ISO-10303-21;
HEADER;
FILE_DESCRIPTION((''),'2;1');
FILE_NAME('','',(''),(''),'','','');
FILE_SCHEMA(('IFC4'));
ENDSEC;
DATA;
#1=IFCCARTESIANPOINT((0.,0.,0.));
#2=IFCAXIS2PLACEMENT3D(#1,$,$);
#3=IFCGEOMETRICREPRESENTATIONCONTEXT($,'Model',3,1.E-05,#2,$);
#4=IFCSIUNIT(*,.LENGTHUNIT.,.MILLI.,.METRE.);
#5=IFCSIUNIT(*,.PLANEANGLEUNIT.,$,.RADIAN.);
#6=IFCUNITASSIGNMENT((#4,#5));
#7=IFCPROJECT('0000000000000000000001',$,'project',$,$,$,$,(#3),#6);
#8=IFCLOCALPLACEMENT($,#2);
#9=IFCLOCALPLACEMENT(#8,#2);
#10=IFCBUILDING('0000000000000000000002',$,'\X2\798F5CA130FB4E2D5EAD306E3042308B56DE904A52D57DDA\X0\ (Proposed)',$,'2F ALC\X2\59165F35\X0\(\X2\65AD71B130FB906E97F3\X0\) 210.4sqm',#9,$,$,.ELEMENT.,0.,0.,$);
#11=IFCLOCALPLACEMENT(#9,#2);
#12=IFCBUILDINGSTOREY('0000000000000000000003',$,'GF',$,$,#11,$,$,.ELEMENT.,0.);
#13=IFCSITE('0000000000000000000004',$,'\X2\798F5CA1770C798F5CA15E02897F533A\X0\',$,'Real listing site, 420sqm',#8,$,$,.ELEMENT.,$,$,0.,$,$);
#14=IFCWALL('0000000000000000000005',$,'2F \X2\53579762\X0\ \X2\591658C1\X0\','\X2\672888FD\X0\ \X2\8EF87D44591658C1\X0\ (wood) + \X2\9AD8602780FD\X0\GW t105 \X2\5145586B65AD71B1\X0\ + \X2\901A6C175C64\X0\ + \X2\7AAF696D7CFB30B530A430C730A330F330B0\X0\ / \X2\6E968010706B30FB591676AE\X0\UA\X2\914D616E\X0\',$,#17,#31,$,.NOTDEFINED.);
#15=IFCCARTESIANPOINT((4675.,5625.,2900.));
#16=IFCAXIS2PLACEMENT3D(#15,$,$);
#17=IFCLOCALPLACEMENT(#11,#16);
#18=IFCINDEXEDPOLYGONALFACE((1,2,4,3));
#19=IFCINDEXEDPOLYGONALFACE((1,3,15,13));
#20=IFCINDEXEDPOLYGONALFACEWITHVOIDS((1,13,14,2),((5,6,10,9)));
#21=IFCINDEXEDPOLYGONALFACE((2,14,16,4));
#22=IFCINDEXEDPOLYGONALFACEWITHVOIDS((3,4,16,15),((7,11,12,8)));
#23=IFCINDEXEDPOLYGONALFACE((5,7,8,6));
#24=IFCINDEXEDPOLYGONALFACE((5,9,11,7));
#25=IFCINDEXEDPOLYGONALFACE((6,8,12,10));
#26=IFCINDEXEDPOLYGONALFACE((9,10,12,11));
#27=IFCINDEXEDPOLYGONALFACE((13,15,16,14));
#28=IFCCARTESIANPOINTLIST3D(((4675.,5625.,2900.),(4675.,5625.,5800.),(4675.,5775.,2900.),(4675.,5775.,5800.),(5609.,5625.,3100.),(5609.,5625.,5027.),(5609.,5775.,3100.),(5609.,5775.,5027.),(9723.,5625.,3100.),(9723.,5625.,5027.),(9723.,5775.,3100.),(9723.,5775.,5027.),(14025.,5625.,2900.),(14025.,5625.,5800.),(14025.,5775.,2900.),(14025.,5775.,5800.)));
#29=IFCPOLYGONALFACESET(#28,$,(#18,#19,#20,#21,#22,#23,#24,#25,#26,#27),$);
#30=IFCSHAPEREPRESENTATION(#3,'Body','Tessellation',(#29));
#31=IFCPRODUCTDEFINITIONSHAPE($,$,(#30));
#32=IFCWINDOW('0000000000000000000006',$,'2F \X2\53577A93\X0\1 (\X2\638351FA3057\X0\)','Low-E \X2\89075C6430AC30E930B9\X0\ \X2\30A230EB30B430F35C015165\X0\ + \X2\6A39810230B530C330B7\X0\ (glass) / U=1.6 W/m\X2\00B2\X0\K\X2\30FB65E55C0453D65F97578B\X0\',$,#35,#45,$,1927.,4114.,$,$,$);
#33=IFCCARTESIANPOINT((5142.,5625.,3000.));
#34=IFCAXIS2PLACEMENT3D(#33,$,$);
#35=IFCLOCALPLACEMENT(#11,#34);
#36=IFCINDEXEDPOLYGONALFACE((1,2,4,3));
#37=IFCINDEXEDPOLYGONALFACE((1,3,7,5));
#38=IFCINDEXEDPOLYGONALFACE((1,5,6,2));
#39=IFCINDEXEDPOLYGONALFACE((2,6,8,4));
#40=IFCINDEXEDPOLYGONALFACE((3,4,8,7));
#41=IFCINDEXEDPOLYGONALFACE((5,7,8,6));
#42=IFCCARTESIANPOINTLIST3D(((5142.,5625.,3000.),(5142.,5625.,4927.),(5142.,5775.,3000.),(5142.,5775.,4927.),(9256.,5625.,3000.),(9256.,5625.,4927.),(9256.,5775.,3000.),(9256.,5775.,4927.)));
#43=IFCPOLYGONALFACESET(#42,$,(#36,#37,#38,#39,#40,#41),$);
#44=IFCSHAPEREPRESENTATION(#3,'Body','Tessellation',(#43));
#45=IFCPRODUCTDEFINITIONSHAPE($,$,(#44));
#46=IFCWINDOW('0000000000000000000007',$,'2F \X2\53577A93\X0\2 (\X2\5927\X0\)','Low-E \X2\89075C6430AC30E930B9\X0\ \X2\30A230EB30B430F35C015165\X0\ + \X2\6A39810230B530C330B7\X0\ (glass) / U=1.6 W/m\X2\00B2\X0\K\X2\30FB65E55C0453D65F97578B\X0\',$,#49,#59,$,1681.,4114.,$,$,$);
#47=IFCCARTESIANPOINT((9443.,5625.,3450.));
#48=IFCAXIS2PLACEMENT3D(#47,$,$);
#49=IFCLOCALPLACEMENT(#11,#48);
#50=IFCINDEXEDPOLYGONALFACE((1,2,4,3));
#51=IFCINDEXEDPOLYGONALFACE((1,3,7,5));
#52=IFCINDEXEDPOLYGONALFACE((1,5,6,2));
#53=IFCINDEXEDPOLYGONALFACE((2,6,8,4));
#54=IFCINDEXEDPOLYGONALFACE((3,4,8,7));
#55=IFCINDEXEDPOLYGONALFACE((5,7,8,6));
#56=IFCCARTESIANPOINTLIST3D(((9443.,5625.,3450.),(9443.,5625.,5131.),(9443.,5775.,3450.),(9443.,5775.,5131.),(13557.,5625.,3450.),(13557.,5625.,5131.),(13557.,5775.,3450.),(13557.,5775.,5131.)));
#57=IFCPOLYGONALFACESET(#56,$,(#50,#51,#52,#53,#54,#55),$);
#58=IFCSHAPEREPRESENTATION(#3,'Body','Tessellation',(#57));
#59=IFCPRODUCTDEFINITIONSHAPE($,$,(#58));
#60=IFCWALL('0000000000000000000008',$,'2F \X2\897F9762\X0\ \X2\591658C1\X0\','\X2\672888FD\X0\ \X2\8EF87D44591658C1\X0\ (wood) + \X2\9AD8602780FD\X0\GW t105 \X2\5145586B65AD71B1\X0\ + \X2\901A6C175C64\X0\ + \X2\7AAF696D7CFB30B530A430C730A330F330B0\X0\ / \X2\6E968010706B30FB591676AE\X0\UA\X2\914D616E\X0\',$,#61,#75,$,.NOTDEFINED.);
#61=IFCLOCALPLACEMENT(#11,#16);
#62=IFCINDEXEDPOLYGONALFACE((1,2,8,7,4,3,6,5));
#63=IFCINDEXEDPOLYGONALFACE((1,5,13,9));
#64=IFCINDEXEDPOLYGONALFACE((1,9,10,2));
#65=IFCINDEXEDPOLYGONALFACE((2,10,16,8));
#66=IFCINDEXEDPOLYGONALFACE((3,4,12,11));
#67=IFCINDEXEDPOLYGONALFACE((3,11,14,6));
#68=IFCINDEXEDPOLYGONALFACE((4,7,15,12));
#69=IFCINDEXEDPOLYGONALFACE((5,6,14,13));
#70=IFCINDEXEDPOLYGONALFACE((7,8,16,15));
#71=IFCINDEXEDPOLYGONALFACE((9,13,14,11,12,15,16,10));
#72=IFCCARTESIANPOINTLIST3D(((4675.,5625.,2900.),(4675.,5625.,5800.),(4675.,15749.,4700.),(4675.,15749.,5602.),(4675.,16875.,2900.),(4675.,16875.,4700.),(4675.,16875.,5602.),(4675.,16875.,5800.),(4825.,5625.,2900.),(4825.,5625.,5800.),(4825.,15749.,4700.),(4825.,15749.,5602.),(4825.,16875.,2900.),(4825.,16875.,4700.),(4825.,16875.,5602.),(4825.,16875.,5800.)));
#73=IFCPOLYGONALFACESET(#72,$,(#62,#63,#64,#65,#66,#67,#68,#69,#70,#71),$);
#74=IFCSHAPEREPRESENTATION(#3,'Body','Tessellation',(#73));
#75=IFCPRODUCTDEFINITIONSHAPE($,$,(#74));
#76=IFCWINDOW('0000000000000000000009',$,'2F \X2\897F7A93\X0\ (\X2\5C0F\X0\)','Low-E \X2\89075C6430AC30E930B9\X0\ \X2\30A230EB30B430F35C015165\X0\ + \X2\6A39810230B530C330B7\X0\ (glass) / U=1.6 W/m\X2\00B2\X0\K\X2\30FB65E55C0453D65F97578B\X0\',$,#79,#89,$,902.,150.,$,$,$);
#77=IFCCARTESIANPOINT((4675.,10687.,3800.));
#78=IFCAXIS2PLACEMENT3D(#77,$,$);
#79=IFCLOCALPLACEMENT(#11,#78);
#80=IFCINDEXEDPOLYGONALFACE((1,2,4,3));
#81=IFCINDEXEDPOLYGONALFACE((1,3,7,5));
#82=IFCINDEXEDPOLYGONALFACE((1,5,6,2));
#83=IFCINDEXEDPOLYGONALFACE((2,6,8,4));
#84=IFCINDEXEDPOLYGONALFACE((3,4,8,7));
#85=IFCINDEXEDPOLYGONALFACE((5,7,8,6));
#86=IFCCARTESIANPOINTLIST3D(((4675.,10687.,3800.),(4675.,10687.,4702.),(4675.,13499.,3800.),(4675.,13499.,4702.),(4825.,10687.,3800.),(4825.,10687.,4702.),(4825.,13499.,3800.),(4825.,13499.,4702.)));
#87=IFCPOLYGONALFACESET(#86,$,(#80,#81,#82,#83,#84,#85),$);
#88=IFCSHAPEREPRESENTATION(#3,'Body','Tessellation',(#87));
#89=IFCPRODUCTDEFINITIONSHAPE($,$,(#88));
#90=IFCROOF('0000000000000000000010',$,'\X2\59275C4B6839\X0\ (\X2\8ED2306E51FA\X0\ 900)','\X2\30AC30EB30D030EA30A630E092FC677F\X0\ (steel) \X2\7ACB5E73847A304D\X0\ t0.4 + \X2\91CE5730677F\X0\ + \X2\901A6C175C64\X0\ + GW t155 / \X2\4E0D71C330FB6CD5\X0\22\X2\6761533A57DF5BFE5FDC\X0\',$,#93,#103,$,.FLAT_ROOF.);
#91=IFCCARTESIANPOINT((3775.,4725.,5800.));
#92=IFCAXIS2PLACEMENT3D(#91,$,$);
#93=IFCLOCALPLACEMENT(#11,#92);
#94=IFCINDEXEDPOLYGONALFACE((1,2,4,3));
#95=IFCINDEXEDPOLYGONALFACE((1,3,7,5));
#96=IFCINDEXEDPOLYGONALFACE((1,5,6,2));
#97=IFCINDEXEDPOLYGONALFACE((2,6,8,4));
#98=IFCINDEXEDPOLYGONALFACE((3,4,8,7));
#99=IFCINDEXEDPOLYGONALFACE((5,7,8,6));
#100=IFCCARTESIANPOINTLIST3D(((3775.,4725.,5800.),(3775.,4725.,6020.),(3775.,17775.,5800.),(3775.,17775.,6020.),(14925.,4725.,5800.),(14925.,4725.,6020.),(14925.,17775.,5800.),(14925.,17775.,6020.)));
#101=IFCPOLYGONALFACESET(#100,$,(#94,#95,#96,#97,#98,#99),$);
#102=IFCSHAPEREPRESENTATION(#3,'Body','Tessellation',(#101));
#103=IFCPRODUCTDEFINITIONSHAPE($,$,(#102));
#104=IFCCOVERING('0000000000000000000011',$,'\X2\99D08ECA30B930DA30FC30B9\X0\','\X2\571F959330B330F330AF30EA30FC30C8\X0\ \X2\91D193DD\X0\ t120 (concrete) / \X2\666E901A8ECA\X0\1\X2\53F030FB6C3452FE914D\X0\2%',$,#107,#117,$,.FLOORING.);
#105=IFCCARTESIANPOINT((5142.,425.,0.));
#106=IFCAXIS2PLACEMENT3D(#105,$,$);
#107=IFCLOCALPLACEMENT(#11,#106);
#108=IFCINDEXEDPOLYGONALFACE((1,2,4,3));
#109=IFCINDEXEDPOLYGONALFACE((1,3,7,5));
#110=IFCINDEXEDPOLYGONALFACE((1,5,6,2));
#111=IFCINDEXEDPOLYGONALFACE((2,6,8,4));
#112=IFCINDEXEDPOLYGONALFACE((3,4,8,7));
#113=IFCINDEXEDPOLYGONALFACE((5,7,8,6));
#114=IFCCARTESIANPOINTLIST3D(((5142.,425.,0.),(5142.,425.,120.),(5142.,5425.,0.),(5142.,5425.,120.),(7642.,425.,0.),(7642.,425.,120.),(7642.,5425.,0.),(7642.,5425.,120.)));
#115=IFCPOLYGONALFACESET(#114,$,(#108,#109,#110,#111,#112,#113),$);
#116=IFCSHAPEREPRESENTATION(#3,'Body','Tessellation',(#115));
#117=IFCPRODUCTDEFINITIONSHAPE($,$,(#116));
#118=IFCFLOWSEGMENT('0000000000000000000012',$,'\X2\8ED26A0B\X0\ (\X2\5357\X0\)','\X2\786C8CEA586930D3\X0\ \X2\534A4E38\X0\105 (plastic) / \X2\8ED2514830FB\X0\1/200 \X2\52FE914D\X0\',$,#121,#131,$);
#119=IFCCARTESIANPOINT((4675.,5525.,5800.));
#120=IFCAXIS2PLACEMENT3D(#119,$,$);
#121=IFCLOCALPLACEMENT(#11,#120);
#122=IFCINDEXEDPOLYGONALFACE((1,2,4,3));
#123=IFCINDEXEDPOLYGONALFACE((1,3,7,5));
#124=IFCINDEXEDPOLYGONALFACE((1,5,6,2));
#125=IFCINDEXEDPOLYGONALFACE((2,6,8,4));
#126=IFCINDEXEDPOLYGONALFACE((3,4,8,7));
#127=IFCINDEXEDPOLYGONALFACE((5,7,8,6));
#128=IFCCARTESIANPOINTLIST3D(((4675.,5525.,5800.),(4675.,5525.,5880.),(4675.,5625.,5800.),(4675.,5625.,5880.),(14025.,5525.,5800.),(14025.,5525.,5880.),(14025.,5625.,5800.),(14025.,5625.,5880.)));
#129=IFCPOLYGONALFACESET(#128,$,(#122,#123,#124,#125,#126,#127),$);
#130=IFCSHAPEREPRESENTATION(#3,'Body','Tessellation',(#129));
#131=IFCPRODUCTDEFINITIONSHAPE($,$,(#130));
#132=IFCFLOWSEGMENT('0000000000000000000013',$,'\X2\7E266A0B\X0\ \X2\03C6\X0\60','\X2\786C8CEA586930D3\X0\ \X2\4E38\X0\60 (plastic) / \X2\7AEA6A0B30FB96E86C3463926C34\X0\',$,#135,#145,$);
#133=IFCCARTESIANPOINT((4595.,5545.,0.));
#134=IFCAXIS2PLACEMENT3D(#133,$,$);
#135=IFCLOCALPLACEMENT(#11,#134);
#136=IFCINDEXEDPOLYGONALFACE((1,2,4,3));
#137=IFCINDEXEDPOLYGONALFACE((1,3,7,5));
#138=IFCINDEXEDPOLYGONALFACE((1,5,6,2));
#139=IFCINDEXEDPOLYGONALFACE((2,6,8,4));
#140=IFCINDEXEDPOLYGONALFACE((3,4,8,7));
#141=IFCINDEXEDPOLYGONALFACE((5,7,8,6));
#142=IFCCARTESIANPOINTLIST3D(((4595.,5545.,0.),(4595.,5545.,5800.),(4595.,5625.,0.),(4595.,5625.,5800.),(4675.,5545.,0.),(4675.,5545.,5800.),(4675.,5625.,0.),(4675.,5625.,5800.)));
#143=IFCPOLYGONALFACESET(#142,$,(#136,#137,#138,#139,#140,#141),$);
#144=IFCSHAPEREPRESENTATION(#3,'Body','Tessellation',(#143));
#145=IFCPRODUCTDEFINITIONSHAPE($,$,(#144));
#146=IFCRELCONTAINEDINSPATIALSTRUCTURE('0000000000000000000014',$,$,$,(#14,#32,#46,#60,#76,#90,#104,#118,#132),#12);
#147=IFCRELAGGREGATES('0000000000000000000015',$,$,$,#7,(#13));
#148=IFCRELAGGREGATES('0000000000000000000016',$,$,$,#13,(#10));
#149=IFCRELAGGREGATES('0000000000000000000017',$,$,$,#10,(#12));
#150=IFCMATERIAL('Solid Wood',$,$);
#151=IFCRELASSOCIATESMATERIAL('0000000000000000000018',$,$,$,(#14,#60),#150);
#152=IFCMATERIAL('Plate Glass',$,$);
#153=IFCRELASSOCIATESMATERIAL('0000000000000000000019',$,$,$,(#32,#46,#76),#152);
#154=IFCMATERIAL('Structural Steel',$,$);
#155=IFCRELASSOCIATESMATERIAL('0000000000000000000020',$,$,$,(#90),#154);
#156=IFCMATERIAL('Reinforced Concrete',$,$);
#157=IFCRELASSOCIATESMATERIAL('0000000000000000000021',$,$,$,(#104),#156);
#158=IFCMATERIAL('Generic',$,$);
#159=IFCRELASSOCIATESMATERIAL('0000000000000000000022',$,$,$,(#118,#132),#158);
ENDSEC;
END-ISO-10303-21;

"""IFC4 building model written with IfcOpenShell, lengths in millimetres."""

from ifc_helpers import new_model, si_unit, frame, frame_2d, origin, place, context, project, spatial, rectangle, extrude, material, element, fill, save


model = new_model("IFC4")

# Units and contexts
model_context = context("Model", 3, precision=1e-05, world=origin())
ifc_project = project(units=[si_unit("LENGTHUNIT", "METRE", prefix="MILLI"), si_unit("PLANEANGLEUNIT", "RADIAN")], contexts=[model_context])

# Site, building, storey
site_placement = place(None, origin())
site = spatial("IfcSite", under=ifc_project, at=site_placement, Name="福岡県福岡市西区", ObjectType="Real listing site, 420sqm", CompositionType="ELEMENT", RefElevation=0.0)
building_placement = place(site_placement, origin())
building = spatial("IfcBuilding", under=site, at=building_placement, Name="福岡・中庭のある回遊動線 (Proposed)", ObjectType="2F ALC外張(断熱・遮音) 210.4sqm", CompositionType="ELEMENT", ElevationOfRefHeight=0.0, ElevationOfTerrain=0.0)
storey_placement = place(building_placement, origin())
storey = spatial("IfcBuildingStorey", under=building, at=storey_placement, Name="GF", CompositionType="ELEMENT", Elevation=0.0)

# Shared definitions
ifc_material_1 = material(Name="Solid Wood")

# Shared definitions
ifc_material_2 = material(Name="Reinforced Concrete")

# Shared definitions
ifc_material_3 = material(Name="Plate Glass")

# Wall, openings, windows
wall_1_placement = place(storey_placement, frame((4675.0, 5625.0, 2900.0)))
wall_1 = element("IfcWall", 1, at=wall_1_placement, inside=storey, material=ifc_material_1, Name="2F 南面 外壁", Description="木製 軸組外壁 (wood) + 高性能GW t105 充填断熱 + 通気層 + 窯業系サイディング / 準耐火・外皮UA配慮", PredefinedType="NOTDEFINED", context=model_context, shape_type="SweptSolid", body=[
    extrude(rectangle(XDim=9350.0, YDim=150.0, at=frame_2d((4675.0, 75.0))), frame((4675.0, 5625.0, 2900.0)), (0.0, 0.0, 1.0), 2900.0),
])
opening_1_placement = place(storey_placement, frame((5142.0, 5625.0, 3000.0)))
opening_1 = element("IfcOpeningElement", 2, at=opening_1_placement, cuts=wall_1, PredefinedType="NOTDEFINED", context=model_context, shape_type="SweptSolid", body=[
    extrude(rectangle(XDim=4114.0, YDim=150.0, at=frame_2d((2057.0, 75.0))), frame((5142.0, 5625.0, 3000.0)), (0.0, 0.0, 1.0), 1927.0),
])
opening_2_placement = place(storey_placement, frame((9443.0, 5625.0, 3450.0)))
opening_2 = element("IfcOpeningElement", 3, at=opening_2_placement, cuts=wall_1, PredefinedType="NOTDEFINED", context=model_context, shape_type="SweptSolid", body=[
    extrude(rectangle(XDim=4114.0, YDim=150.0, at=frame_2d((2057.0, 75.0))), frame((9443.0, 5625.0, 3450.0)), (0.0, 0.0, 1.0), 1681.0),
])
window_1_placement = place(storey_placement, frame((5142.0, 5625.0, 3000.0)))
window_1 = element("IfcWindow", 4, at=window_1_placement, inside=storey, material=ifc_material_3, Name="2F 南窓1 (掃出し)", Description="Low-E 複層ガラス アルゴン封入 + 樹脂サッシ (glass) / U=1.6 W/m²K・日射取得型", OverallHeight=1927.0, OverallWidth=4114.0, context=model_context, shape_type="SweptSolid", body=[
    extrude(rectangle(XDim=4114.0, YDim=150.0, at=frame_2d((2057.0, 75.0))), frame((5142.0, 5625.0, 3000.0)), (0.0, 0.0, 1.0), 1927.0),
])
fill(opening_1, window_1)
window_2_placement = place(storey_placement, frame((9443.0, 5625.0, 3450.0)))
window_2 = element("IfcWindow", 5, at=window_2_placement, inside=storey, material=ifc_material_3, Name="2F 南窓2 (大)", Description="Low-E 複層ガラス アルゴン封入 + 樹脂サッシ (glass) / U=1.6 W/m²K・日射取得型", OverallHeight=1681.0, OverallWidth=4114.0, context=model_context, shape_type="SweptSolid", body=[
    extrude(rectangle(XDim=4114.0, YDim=150.0, at=frame_2d((2057.0, 75.0))), frame((9443.0, 5625.0, 3450.0)), (0.0, 0.0, 1.0), 1681.0),
])
fill(opening_2, window_2)

# Wall, opening, window
wall_2_placement = place(storey_placement, frame((4675.0, 5625.0, 2900.0)))
wall_2 = element("IfcWall", 6, at=wall_2_placement, inside=storey, material=ifc_material_1, Name="2F 西面 外壁", Description="木製 軸組外壁 (wood) + 高性能GW t105 充填断熱 + 通気層 + 窯業系サイディング / 準耐火・外皮UA配慮", PredefinedType="NOTDEFINED", context=model_context, shape_type="SweptSolid", body=[
    extrude(rectangle(XDim=150.0, YDim=11250.0, at=frame_2d((75.0, 5625.0))), frame((4675.0, 5625.0, 2900.0)), (0.0, 0.0, 1.0), 2900.0),
])
opening_3_placement = place(storey_placement, frame((4675.0, 10687.0, 3800.0)))
opening_3 = element("IfcOpeningElement", 7, at=opening_3_placement, cuts=wall_2, PredefinedType="NOTDEFINED", context=model_context, shape_type="SweptSolid", body=[
    extrude(rectangle(XDim=150.0, YDim=2812.0, at=frame_2d((75.0, 1406.0))), frame((4675.0, 10687.0, 3800.0)), (0.0, 0.0, 1.0), 902.0),
])
window_3_placement = place(storey_placement, frame((4675.0, 10687.0, 3800.0)))
window_3 = element("IfcWindow", 8, at=window_3_placement, inside=storey, material=ifc_material_3, Name="2F 西窓 (小)", Description="Low-E 複層ガラス アルゴン封入 + 樹脂サッシ (glass) / U=1.6 W/m²K・日射取得型", OverallHeight=902.0, OverallWidth=150.0, context=model_context, shape_type="SweptSolid", body=[
    extrude(rectangle(XDim=150.0, YDim=2812.0, at=frame_2d((75.0, 1406.0))), frame((4675.0, 10687.0, 3800.0)), (0.0, 0.0, 1.0), 902.0),
])
fill(opening_3, window_3)

# Roof
ifc_material_4 = material(Name="Structural Steel")
roof_placement = place(storey_placement, frame((3775.0, 4725.0, 5800.0)))
element("IfcRoof", 9, at=roof_placement, inside=storey, material=ifc_material_4, Name="大屋根 (軒の出 900)", Description="ガルバリウム鋼板 (steel) 立平葺き t0.4 + 野地板 + 通気層 + GW t155 / 不燃・法22条区域対応", PredefinedType="FLAT_ROOF", context=model_context, shape_type="SweptSolid", body=[
    extrude(rectangle(XDim=11150.0, YDim=13050.0, at=frame_2d((5575.0, 6525.0))), frame((3775.0, 4725.0, 5800.0)), (0.0, 0.0, 1.0), 220.0),
])

# Covering
covering_placement = place(storey_placement, frame((5142.0, 425.0, 0.0)))
element("IfcCovering", 10, at=covering_placement, inside=storey, material=ifc_material_2, Name="駐車スペース", Description="土間コンクリート 金鏝 t120 (concrete) / 普通車1台・水勾配2%", PredefinedType="FLOORING", context=model_context, shape_type="SweptSolid", body=[
    extrude(rectangle(XDim=2500.0, YDim=5000.0, at=frame_2d((1250.0, 2500.0))), frame((5142.0, 425.0, 0.0)), (0.0, 0.0, 1.0), 120.0),
])

# Flow segments
ifc_material_5 = material(Name="Generic")
flow_segment_1_placement = place(storey_placement, frame((4675.0, 5525.0, 5800.0)))
element("IfcFlowSegment", 11, at=flow_segment_1_placement, inside=storey, material=ifc_material_5, Name="軒樋 (南)", Description="硬質塩ビ 半丸105 (plastic) / 軒先・1/200 勾配", context=model_context, shape_type="SweptSolid", body=[
    extrude(rectangle(XDim=9350.0, YDim=100.0, at=frame_2d((4675.0, 50.0))), frame((4675.0, 5525.0, 5800.0)), (0.0, 0.0, 1.0), 80.0),
])
flow_segment_2_placement = place(storey_placement, frame((4595.0, 5545.0, 0.0)))
element("IfcFlowSegment", 12, at=flow_segment_2_placement, inside=storey, material=ifc_material_5, Name="縦樋 φ60", Description="硬質塩ビ 丸60 (plastic) / 竪樋・雨水排水", context=model_context, shape_type="SweptSolid", body=[
    extrude(rectangle(XDim=80.0, YDim=80.0, at=frame_2d((40.0, 40.0))), frame((4595.0, 5545.0, 0.0)), (0.0, 0.0, 1.0), 5800.0),
])

save(model, "model.ifc")
